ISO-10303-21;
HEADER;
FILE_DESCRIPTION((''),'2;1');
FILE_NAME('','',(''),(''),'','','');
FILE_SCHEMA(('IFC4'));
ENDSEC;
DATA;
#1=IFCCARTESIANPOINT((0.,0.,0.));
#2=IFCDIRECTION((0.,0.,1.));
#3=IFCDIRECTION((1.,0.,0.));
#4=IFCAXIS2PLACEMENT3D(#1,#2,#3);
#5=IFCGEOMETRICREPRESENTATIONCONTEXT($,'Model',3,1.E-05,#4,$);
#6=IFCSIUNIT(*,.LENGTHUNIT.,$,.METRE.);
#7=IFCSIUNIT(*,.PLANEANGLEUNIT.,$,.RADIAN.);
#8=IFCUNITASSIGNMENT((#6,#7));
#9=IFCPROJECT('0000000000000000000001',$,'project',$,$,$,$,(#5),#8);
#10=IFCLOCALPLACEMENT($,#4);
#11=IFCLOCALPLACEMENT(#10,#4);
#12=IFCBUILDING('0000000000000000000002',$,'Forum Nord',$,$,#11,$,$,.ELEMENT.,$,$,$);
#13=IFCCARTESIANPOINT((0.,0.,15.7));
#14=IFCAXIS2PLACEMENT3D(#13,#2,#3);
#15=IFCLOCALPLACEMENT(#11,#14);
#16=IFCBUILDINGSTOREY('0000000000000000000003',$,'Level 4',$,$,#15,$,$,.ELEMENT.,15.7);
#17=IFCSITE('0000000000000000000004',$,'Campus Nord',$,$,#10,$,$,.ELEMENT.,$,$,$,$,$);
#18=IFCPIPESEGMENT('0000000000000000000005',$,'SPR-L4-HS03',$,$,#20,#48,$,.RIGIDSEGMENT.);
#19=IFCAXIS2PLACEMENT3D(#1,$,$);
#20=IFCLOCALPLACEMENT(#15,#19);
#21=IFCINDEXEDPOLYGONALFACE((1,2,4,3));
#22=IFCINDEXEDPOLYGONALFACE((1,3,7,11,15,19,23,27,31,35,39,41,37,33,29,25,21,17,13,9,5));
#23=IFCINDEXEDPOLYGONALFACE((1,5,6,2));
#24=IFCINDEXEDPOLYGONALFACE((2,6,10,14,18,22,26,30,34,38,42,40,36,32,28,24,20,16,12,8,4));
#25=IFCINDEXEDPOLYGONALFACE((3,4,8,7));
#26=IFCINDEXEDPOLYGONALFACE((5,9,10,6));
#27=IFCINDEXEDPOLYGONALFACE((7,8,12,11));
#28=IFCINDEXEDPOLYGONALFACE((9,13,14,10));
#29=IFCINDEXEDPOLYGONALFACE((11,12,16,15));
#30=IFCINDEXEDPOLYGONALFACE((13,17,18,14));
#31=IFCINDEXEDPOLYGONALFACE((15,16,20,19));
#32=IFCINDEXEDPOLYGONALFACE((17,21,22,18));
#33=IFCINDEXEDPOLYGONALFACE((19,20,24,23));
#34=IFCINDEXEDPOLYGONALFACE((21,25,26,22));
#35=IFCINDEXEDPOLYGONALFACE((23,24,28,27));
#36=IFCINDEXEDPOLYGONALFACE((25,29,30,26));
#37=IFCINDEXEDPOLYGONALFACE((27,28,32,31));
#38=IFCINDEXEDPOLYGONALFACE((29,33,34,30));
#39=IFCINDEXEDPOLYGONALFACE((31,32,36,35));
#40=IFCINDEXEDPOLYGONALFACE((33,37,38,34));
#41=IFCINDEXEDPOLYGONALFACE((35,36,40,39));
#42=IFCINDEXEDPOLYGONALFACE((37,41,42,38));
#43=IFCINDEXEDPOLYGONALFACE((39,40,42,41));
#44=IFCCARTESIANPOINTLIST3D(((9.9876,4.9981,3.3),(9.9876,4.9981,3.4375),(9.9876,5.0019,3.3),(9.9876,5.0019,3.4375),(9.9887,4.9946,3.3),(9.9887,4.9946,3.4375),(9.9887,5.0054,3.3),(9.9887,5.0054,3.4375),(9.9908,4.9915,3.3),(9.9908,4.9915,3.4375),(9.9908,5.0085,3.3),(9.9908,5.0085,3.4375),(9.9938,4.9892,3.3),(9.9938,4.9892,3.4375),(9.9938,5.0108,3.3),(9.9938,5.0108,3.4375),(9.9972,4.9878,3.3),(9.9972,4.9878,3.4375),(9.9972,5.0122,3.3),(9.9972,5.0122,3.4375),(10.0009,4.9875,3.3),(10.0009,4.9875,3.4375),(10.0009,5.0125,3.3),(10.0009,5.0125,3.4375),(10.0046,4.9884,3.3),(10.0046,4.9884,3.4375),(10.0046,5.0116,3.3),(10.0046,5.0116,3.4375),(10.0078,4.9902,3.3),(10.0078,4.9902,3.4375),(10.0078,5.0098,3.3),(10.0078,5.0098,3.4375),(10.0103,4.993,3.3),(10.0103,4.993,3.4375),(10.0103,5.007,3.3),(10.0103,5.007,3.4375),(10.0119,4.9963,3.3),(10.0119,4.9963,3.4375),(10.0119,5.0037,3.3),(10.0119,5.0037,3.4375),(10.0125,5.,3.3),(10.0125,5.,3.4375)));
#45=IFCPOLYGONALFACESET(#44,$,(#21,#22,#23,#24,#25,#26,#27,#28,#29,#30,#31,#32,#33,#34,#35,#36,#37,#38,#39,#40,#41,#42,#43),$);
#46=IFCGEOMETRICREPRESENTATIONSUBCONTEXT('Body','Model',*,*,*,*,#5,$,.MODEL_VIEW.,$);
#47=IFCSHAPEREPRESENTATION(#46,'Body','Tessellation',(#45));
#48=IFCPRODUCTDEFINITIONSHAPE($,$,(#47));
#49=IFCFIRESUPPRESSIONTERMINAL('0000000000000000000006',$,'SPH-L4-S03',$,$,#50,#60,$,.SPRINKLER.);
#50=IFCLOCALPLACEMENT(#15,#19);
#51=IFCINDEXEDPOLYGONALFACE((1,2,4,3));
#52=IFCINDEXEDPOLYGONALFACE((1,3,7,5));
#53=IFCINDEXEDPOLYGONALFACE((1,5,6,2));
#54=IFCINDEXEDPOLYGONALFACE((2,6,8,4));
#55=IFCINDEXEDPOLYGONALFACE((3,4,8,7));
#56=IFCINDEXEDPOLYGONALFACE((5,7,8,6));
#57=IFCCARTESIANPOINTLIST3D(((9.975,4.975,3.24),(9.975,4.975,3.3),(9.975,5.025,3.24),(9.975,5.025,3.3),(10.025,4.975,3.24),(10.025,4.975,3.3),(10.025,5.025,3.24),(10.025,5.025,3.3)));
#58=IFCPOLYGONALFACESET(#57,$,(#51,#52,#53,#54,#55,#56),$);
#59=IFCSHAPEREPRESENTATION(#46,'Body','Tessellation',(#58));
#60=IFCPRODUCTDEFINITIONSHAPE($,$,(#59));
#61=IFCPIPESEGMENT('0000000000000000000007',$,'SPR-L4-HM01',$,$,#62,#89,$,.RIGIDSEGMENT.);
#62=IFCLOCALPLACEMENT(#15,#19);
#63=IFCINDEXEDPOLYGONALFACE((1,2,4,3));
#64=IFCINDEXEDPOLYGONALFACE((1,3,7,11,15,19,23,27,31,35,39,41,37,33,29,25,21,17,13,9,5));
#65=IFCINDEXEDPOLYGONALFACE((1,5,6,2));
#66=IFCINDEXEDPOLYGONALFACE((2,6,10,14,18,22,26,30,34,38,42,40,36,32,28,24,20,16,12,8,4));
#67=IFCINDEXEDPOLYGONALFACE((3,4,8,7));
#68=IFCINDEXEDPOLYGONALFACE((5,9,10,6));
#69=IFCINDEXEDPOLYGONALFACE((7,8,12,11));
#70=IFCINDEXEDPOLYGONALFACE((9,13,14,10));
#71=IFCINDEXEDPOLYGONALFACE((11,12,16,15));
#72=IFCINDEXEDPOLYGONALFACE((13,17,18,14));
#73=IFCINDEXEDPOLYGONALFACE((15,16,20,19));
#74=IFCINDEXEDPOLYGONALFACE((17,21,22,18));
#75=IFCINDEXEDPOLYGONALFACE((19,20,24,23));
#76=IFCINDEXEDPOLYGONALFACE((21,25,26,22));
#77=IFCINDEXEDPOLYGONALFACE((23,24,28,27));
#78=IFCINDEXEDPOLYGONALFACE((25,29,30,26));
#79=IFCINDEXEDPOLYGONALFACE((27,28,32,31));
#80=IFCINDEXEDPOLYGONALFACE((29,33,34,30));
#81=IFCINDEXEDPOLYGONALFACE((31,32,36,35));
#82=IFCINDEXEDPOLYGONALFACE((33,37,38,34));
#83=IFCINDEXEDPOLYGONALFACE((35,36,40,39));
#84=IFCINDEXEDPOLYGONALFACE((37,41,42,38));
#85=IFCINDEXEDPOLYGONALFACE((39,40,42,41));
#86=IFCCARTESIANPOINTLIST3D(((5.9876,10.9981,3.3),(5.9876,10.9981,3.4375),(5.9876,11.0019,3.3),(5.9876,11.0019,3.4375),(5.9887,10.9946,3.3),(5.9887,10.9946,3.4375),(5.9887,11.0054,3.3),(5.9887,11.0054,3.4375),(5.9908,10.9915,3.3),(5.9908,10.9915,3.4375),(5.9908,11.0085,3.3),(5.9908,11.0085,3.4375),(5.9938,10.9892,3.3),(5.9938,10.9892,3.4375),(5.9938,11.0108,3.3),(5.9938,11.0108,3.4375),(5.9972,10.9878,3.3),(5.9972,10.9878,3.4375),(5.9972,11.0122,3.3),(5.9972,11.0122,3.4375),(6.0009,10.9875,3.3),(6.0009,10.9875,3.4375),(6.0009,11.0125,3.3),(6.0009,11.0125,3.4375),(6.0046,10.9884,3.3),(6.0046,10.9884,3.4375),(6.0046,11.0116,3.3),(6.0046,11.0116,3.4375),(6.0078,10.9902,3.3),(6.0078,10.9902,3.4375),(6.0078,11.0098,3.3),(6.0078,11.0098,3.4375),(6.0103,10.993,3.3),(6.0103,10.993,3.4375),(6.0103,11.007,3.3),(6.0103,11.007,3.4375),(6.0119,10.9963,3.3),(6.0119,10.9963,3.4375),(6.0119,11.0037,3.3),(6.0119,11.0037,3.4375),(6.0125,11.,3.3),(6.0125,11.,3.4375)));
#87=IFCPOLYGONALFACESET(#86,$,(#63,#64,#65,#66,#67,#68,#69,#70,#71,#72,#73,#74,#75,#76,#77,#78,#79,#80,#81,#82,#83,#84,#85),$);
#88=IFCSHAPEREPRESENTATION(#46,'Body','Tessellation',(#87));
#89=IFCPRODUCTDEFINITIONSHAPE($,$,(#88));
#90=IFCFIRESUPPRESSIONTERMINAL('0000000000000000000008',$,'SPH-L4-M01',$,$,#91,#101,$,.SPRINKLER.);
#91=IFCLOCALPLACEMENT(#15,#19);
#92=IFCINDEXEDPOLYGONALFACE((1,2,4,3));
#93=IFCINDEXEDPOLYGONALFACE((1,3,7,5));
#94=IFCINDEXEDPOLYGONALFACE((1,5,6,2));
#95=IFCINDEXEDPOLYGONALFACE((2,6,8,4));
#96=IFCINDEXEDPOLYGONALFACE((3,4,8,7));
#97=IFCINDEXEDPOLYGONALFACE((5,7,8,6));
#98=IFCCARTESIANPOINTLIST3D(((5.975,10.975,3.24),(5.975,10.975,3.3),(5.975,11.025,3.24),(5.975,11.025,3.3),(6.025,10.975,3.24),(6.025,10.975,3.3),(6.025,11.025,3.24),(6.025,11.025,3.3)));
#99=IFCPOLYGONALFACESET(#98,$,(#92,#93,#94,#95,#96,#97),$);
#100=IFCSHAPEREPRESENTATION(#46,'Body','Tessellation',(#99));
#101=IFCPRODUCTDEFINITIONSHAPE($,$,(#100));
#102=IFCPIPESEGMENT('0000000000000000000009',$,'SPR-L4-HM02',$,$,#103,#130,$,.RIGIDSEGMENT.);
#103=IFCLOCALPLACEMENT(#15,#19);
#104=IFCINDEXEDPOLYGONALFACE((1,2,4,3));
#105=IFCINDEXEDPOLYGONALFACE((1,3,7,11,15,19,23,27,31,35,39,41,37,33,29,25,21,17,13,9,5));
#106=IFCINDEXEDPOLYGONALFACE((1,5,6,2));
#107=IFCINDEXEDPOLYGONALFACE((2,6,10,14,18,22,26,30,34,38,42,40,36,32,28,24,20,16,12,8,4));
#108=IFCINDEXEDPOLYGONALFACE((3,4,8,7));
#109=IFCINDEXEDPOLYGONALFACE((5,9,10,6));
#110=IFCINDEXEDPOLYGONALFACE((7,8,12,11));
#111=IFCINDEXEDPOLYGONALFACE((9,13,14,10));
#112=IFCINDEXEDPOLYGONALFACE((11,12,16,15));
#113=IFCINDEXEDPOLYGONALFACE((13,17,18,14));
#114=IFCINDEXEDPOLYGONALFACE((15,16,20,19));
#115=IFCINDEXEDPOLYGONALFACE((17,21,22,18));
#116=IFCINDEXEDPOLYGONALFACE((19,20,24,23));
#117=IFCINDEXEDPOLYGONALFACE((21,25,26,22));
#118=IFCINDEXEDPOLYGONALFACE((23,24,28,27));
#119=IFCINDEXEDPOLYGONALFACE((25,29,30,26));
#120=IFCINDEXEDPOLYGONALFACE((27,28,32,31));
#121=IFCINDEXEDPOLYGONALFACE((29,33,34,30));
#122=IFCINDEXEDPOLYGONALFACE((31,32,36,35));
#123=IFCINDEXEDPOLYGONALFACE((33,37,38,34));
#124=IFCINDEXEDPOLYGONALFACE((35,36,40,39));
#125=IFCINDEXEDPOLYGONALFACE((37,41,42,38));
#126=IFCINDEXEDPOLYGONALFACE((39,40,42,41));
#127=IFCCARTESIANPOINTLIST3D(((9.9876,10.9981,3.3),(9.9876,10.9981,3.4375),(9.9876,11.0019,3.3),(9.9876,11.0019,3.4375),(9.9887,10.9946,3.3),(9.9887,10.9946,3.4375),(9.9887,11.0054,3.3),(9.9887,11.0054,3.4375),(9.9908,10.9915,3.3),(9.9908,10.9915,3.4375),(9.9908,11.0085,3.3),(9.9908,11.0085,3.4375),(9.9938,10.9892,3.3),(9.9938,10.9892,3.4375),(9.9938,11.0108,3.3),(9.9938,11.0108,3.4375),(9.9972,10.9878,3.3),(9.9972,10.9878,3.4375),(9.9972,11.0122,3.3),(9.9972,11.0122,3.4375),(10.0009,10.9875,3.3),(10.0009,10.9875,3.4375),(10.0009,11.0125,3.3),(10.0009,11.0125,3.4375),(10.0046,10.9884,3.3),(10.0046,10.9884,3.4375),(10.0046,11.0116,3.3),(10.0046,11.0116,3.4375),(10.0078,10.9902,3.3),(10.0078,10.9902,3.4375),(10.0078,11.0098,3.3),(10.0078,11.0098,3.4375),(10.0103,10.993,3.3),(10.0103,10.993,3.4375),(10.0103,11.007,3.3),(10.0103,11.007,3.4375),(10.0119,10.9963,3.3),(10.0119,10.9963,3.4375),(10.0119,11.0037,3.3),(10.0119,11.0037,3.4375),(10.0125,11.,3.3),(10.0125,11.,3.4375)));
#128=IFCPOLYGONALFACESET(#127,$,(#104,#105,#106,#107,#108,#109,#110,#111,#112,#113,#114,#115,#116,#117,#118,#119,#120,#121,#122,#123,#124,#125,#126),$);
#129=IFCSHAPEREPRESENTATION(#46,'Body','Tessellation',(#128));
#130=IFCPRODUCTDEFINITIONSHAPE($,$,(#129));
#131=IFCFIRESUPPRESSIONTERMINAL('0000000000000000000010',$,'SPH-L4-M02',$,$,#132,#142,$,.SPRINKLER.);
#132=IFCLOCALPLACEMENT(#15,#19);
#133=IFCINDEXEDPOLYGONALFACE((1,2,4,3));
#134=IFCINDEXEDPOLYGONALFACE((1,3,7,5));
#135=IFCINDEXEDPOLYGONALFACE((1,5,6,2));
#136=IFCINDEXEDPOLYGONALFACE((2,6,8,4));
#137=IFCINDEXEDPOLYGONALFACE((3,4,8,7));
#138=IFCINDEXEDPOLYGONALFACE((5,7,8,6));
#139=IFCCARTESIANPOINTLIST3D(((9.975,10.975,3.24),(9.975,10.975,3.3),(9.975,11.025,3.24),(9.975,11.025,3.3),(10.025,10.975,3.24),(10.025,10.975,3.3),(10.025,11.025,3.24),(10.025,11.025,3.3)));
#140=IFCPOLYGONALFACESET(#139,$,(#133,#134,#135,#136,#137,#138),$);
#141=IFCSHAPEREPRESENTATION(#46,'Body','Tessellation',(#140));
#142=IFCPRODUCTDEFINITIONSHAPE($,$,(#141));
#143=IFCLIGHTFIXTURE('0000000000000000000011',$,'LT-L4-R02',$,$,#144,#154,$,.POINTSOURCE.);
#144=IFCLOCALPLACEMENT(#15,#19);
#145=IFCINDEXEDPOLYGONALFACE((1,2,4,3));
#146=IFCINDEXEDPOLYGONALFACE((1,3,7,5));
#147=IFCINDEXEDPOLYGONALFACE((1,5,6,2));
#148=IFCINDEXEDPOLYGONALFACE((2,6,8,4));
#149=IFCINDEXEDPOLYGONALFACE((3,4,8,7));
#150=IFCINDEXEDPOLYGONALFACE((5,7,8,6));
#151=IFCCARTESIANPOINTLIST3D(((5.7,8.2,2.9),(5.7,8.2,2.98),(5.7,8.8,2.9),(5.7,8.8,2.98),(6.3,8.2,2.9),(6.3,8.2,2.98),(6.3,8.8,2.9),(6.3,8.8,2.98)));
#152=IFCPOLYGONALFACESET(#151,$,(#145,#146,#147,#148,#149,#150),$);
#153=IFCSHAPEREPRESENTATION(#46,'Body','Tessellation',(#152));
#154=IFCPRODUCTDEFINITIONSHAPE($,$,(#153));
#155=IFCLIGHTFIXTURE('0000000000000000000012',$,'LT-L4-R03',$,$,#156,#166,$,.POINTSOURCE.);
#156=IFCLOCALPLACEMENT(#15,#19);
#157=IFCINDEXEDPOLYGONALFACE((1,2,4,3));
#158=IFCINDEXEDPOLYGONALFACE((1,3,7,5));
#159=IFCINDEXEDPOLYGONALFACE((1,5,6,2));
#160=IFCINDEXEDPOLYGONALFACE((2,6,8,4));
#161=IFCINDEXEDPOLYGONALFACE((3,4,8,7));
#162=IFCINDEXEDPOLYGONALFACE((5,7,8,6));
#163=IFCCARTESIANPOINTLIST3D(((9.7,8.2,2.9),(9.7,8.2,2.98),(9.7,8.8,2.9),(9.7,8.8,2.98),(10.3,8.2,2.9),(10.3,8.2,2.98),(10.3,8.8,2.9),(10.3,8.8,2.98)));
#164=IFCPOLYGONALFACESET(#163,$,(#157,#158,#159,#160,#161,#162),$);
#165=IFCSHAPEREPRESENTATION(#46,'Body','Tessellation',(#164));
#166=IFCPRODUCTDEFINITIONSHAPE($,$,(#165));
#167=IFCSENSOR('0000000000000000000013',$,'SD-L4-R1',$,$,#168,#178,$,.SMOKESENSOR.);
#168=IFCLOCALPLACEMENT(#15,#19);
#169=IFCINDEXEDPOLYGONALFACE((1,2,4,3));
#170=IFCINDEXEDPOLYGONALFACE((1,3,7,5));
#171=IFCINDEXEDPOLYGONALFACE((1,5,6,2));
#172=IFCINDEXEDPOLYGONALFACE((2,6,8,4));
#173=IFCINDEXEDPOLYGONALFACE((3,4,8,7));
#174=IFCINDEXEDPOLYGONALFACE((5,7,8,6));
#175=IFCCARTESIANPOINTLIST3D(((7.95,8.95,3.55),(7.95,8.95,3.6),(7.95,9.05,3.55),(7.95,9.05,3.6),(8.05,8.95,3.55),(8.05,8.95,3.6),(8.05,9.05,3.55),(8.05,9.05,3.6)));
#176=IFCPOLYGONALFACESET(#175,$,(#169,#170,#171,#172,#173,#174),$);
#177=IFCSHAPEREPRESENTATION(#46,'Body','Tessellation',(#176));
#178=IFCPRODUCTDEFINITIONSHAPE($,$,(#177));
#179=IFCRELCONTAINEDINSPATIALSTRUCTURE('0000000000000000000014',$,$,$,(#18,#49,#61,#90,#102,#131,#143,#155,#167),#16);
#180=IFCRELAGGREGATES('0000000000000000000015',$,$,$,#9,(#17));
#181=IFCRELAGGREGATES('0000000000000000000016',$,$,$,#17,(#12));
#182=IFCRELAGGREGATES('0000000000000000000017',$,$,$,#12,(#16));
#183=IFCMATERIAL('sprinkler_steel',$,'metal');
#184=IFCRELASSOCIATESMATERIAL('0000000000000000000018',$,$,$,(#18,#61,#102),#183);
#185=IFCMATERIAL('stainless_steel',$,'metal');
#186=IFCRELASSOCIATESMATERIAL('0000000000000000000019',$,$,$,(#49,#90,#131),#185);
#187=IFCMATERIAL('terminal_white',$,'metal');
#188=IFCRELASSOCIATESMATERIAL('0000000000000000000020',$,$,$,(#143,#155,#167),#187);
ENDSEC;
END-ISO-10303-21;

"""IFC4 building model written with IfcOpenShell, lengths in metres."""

from ifc_helpers import new_model, si_unit, frame, origin_with_axes, origin_2d_with_axis, place, context, subcontext, project, spatial, rectangle, circle, extrude, material, element, save


model = new_model("IFC4")

# Units and contexts
model_context = context("Model", 3, precision=1e-05, world=origin_with_axes())
body_context = subcontext(model_context, "Body", "Model", "MODEL_VIEW")
ifc_project = project(units=[si_unit("LENGTHUNIT", "METRE"), si_unit("PLANEANGLEUNIT", "RADIAN")], contexts=[model_context])

# Site, building, storey
site_placement = place(None, origin_with_axes())
site = spatial("IfcSite", under=ifc_project, at=site_placement, Name="Campus Nord", CompositionType="ELEMENT")
building_placement = place(site_placement, origin_with_axes())
building = spatial("IfcBuilding", under=site, at=building_placement, Name="Forum Nord", CompositionType="ELEMENT")
storey_placement = place(building_placement, frame((0.0, 0.0, 15.7), z_axis=(0.0, 0.0, 1.0), x_axis=(1.0, 0.0, 0.0)))
storey = spatial("IfcBuildingStorey", under=building, at=storey_placement, Name="Level 4", CompositionType="ELEMENT", Elevation=15.7)

# Shared definitions
ifc_material_1 = material(Name="terminal_white", Category="metal")

# Shared definitions
ifc_material_2 = material(Name="sprinkler_steel", Category="metal")

# Pipe segment
pipe_segment_1_placement = place(storey_placement, frame((10.0, 5.0, 3.4375), z_axis=(0.0, 0.0, -1.0), x_axis=(1.0, 0.0, 0.0)))
element("IfcPipeSegment", 1, at=pipe_segment_1_placement, inside=storey, material=ifc_material_2, Name="SPR-L4-HS03", PredefinedType="RIGIDSEGMENT", context=body_context, shape_type="SweptSolid", body=[
    extrude(circle(Radius=0.0125, at=origin_2d_with_axis()), origin_with_axes(), (0.0, 0.0, 1.0), 0.1375),
])

# Fire suppression terminal
ifc_material_3 = material(Name="stainless_steel", Category="metal")
fire_suppression_terminal_1_placement = place(storey_placement, frame((10.0, 5.0, 3.24), z_axis=(0.0, 0.0, 1.0), x_axis=(1.0, 0.0, 0.0)))
element("IfcFireSuppressionTerminal", 2, at=fire_suppression_terminal_1_placement, inside=storey, material=ifc_material_3, Name="SPH-L4-S03", PredefinedType="SPRINKLER", context=body_context, shape_type="SweptSolid", body=[
    extrude(rectangle(XDim=0.05, YDim=0.05, at=origin_2d_with_axis()), origin_with_axes(), (0.0, 0.0, 1.0), 0.06),
])

# Pipe segment
pipe_segment_2_placement = place(storey_placement, frame((6.0, 11.0, 3.4375), z_axis=(0.0, 0.0, -1.0), x_axis=(1.0, 0.0, 0.0)))
element("IfcPipeSegment", 3, at=pipe_segment_2_placement, inside=storey, material=ifc_material_2, Name="SPR-L4-HM01", PredefinedType="RIGIDSEGMENT", context=body_context, shape_type="SweptSolid", body=[
    extrude(circle(Radius=0.0125, at=origin_2d_with_axis()), origin_with_axes(), (0.0, 0.0, 1.0), 0.1375),
])

# Fire suppression terminal
fire_suppression_terminal_2_placement = place(storey_placement, frame((6.0, 11.0, 3.24), z_axis=(0.0, 0.0, 1.0), x_axis=(1.0, 0.0, 0.0)))
element("IfcFireSuppressionTerminal", 4, at=fire_suppression_terminal_2_placement, inside=storey, material=ifc_material_3, Name="SPH-L4-M01", PredefinedType="SPRINKLER", context=body_context, shape_type="SweptSolid", body=[
    extrude(rectangle(XDim=0.05, YDim=0.05, at=origin_2d_with_axis()), origin_with_axes(), (0.0, 0.0, 1.0), 0.06),
])

# Pipe segment
pipe_segment_3_placement = place(storey_placement, frame((10.0, 11.0, 3.4375), z_axis=(0.0, 0.0, -1.0), x_axis=(1.0, 0.0, 0.0)))
element("IfcPipeSegment", 5, at=pipe_segment_3_placement, inside=storey, material=ifc_material_2, Name="SPR-L4-HM02", PredefinedType="RIGIDSEGMENT", context=body_context, shape_type="SweptSolid", body=[
    extrude(circle(Radius=0.0125, at=origin_2d_with_axis()), origin_with_axes(), (0.0, 0.0, 1.0), 0.1375),
])

# Fire suppression terminal
fire_suppression_terminal_3_placement = place(storey_placement, frame((10.0, 11.0, 3.24), z_axis=(0.0, 0.0, 1.0), x_axis=(1.0, 0.0, 0.0)))
element("IfcFireSuppressionTerminal", 6, at=fire_suppression_terminal_3_placement, inside=storey, material=ifc_material_3, Name="SPH-L4-M02", PredefinedType="SPRINKLER", context=body_context, shape_type="SweptSolid", body=[
    extrude(rectangle(XDim=0.05, YDim=0.05, at=origin_2d_with_axis()), origin_with_axes(), (0.0, 0.0, 1.0), 0.06),
])

# Light fixtures
for number, where, z_axis, x_axis, name in (
    (7, (6.0, 8.5, 2.9), (0.0, 0.0, 1.0), (1.0, 0.0, 0.0), "LT-L4-R02"),
    (8, (10.0, 8.5, 2.9), (0.0, 0.0, 1.0), (1.0, 0.0, 0.0), "LT-L4-R03"),
):
    element("IfcLightFixture", number, at=place(storey_placement, frame(where, z_axis=z_axis, x_axis=x_axis)), inside=storey, material=ifc_material_1, Name=name, PredefinedType="POINTSOURCE", context=body_context, shape_type="SweptSolid", body=[
        extrude(rectangle(XDim=0.6, YDim=0.6, at=origin_2d_with_axis()), origin_with_axes(), (0.0, 0.0, 1.0), 0.08),
    ])

# Sensor
sensor_placement = place(storey_placement, frame((8.0, 9.0, 3.55), z_axis=(0.0, 0.0, 1.0), x_axis=(1.0, 0.0, 0.0)))
element("IfcSensor", 9, at=sensor_placement, inside=storey, material=ifc_material_1, Name="SD-L4-R1", PredefinedType="SMOKESENSOR", context=body_context, shape_type="SweptSolid", body=[
    extrude(rectangle(XDim=0.1, YDim=0.1, at=origin_2d_with_axis()), origin_with_axes(), (0.0, 0.0, 1.0), 0.05),
])

save(model, "model.ifc")
